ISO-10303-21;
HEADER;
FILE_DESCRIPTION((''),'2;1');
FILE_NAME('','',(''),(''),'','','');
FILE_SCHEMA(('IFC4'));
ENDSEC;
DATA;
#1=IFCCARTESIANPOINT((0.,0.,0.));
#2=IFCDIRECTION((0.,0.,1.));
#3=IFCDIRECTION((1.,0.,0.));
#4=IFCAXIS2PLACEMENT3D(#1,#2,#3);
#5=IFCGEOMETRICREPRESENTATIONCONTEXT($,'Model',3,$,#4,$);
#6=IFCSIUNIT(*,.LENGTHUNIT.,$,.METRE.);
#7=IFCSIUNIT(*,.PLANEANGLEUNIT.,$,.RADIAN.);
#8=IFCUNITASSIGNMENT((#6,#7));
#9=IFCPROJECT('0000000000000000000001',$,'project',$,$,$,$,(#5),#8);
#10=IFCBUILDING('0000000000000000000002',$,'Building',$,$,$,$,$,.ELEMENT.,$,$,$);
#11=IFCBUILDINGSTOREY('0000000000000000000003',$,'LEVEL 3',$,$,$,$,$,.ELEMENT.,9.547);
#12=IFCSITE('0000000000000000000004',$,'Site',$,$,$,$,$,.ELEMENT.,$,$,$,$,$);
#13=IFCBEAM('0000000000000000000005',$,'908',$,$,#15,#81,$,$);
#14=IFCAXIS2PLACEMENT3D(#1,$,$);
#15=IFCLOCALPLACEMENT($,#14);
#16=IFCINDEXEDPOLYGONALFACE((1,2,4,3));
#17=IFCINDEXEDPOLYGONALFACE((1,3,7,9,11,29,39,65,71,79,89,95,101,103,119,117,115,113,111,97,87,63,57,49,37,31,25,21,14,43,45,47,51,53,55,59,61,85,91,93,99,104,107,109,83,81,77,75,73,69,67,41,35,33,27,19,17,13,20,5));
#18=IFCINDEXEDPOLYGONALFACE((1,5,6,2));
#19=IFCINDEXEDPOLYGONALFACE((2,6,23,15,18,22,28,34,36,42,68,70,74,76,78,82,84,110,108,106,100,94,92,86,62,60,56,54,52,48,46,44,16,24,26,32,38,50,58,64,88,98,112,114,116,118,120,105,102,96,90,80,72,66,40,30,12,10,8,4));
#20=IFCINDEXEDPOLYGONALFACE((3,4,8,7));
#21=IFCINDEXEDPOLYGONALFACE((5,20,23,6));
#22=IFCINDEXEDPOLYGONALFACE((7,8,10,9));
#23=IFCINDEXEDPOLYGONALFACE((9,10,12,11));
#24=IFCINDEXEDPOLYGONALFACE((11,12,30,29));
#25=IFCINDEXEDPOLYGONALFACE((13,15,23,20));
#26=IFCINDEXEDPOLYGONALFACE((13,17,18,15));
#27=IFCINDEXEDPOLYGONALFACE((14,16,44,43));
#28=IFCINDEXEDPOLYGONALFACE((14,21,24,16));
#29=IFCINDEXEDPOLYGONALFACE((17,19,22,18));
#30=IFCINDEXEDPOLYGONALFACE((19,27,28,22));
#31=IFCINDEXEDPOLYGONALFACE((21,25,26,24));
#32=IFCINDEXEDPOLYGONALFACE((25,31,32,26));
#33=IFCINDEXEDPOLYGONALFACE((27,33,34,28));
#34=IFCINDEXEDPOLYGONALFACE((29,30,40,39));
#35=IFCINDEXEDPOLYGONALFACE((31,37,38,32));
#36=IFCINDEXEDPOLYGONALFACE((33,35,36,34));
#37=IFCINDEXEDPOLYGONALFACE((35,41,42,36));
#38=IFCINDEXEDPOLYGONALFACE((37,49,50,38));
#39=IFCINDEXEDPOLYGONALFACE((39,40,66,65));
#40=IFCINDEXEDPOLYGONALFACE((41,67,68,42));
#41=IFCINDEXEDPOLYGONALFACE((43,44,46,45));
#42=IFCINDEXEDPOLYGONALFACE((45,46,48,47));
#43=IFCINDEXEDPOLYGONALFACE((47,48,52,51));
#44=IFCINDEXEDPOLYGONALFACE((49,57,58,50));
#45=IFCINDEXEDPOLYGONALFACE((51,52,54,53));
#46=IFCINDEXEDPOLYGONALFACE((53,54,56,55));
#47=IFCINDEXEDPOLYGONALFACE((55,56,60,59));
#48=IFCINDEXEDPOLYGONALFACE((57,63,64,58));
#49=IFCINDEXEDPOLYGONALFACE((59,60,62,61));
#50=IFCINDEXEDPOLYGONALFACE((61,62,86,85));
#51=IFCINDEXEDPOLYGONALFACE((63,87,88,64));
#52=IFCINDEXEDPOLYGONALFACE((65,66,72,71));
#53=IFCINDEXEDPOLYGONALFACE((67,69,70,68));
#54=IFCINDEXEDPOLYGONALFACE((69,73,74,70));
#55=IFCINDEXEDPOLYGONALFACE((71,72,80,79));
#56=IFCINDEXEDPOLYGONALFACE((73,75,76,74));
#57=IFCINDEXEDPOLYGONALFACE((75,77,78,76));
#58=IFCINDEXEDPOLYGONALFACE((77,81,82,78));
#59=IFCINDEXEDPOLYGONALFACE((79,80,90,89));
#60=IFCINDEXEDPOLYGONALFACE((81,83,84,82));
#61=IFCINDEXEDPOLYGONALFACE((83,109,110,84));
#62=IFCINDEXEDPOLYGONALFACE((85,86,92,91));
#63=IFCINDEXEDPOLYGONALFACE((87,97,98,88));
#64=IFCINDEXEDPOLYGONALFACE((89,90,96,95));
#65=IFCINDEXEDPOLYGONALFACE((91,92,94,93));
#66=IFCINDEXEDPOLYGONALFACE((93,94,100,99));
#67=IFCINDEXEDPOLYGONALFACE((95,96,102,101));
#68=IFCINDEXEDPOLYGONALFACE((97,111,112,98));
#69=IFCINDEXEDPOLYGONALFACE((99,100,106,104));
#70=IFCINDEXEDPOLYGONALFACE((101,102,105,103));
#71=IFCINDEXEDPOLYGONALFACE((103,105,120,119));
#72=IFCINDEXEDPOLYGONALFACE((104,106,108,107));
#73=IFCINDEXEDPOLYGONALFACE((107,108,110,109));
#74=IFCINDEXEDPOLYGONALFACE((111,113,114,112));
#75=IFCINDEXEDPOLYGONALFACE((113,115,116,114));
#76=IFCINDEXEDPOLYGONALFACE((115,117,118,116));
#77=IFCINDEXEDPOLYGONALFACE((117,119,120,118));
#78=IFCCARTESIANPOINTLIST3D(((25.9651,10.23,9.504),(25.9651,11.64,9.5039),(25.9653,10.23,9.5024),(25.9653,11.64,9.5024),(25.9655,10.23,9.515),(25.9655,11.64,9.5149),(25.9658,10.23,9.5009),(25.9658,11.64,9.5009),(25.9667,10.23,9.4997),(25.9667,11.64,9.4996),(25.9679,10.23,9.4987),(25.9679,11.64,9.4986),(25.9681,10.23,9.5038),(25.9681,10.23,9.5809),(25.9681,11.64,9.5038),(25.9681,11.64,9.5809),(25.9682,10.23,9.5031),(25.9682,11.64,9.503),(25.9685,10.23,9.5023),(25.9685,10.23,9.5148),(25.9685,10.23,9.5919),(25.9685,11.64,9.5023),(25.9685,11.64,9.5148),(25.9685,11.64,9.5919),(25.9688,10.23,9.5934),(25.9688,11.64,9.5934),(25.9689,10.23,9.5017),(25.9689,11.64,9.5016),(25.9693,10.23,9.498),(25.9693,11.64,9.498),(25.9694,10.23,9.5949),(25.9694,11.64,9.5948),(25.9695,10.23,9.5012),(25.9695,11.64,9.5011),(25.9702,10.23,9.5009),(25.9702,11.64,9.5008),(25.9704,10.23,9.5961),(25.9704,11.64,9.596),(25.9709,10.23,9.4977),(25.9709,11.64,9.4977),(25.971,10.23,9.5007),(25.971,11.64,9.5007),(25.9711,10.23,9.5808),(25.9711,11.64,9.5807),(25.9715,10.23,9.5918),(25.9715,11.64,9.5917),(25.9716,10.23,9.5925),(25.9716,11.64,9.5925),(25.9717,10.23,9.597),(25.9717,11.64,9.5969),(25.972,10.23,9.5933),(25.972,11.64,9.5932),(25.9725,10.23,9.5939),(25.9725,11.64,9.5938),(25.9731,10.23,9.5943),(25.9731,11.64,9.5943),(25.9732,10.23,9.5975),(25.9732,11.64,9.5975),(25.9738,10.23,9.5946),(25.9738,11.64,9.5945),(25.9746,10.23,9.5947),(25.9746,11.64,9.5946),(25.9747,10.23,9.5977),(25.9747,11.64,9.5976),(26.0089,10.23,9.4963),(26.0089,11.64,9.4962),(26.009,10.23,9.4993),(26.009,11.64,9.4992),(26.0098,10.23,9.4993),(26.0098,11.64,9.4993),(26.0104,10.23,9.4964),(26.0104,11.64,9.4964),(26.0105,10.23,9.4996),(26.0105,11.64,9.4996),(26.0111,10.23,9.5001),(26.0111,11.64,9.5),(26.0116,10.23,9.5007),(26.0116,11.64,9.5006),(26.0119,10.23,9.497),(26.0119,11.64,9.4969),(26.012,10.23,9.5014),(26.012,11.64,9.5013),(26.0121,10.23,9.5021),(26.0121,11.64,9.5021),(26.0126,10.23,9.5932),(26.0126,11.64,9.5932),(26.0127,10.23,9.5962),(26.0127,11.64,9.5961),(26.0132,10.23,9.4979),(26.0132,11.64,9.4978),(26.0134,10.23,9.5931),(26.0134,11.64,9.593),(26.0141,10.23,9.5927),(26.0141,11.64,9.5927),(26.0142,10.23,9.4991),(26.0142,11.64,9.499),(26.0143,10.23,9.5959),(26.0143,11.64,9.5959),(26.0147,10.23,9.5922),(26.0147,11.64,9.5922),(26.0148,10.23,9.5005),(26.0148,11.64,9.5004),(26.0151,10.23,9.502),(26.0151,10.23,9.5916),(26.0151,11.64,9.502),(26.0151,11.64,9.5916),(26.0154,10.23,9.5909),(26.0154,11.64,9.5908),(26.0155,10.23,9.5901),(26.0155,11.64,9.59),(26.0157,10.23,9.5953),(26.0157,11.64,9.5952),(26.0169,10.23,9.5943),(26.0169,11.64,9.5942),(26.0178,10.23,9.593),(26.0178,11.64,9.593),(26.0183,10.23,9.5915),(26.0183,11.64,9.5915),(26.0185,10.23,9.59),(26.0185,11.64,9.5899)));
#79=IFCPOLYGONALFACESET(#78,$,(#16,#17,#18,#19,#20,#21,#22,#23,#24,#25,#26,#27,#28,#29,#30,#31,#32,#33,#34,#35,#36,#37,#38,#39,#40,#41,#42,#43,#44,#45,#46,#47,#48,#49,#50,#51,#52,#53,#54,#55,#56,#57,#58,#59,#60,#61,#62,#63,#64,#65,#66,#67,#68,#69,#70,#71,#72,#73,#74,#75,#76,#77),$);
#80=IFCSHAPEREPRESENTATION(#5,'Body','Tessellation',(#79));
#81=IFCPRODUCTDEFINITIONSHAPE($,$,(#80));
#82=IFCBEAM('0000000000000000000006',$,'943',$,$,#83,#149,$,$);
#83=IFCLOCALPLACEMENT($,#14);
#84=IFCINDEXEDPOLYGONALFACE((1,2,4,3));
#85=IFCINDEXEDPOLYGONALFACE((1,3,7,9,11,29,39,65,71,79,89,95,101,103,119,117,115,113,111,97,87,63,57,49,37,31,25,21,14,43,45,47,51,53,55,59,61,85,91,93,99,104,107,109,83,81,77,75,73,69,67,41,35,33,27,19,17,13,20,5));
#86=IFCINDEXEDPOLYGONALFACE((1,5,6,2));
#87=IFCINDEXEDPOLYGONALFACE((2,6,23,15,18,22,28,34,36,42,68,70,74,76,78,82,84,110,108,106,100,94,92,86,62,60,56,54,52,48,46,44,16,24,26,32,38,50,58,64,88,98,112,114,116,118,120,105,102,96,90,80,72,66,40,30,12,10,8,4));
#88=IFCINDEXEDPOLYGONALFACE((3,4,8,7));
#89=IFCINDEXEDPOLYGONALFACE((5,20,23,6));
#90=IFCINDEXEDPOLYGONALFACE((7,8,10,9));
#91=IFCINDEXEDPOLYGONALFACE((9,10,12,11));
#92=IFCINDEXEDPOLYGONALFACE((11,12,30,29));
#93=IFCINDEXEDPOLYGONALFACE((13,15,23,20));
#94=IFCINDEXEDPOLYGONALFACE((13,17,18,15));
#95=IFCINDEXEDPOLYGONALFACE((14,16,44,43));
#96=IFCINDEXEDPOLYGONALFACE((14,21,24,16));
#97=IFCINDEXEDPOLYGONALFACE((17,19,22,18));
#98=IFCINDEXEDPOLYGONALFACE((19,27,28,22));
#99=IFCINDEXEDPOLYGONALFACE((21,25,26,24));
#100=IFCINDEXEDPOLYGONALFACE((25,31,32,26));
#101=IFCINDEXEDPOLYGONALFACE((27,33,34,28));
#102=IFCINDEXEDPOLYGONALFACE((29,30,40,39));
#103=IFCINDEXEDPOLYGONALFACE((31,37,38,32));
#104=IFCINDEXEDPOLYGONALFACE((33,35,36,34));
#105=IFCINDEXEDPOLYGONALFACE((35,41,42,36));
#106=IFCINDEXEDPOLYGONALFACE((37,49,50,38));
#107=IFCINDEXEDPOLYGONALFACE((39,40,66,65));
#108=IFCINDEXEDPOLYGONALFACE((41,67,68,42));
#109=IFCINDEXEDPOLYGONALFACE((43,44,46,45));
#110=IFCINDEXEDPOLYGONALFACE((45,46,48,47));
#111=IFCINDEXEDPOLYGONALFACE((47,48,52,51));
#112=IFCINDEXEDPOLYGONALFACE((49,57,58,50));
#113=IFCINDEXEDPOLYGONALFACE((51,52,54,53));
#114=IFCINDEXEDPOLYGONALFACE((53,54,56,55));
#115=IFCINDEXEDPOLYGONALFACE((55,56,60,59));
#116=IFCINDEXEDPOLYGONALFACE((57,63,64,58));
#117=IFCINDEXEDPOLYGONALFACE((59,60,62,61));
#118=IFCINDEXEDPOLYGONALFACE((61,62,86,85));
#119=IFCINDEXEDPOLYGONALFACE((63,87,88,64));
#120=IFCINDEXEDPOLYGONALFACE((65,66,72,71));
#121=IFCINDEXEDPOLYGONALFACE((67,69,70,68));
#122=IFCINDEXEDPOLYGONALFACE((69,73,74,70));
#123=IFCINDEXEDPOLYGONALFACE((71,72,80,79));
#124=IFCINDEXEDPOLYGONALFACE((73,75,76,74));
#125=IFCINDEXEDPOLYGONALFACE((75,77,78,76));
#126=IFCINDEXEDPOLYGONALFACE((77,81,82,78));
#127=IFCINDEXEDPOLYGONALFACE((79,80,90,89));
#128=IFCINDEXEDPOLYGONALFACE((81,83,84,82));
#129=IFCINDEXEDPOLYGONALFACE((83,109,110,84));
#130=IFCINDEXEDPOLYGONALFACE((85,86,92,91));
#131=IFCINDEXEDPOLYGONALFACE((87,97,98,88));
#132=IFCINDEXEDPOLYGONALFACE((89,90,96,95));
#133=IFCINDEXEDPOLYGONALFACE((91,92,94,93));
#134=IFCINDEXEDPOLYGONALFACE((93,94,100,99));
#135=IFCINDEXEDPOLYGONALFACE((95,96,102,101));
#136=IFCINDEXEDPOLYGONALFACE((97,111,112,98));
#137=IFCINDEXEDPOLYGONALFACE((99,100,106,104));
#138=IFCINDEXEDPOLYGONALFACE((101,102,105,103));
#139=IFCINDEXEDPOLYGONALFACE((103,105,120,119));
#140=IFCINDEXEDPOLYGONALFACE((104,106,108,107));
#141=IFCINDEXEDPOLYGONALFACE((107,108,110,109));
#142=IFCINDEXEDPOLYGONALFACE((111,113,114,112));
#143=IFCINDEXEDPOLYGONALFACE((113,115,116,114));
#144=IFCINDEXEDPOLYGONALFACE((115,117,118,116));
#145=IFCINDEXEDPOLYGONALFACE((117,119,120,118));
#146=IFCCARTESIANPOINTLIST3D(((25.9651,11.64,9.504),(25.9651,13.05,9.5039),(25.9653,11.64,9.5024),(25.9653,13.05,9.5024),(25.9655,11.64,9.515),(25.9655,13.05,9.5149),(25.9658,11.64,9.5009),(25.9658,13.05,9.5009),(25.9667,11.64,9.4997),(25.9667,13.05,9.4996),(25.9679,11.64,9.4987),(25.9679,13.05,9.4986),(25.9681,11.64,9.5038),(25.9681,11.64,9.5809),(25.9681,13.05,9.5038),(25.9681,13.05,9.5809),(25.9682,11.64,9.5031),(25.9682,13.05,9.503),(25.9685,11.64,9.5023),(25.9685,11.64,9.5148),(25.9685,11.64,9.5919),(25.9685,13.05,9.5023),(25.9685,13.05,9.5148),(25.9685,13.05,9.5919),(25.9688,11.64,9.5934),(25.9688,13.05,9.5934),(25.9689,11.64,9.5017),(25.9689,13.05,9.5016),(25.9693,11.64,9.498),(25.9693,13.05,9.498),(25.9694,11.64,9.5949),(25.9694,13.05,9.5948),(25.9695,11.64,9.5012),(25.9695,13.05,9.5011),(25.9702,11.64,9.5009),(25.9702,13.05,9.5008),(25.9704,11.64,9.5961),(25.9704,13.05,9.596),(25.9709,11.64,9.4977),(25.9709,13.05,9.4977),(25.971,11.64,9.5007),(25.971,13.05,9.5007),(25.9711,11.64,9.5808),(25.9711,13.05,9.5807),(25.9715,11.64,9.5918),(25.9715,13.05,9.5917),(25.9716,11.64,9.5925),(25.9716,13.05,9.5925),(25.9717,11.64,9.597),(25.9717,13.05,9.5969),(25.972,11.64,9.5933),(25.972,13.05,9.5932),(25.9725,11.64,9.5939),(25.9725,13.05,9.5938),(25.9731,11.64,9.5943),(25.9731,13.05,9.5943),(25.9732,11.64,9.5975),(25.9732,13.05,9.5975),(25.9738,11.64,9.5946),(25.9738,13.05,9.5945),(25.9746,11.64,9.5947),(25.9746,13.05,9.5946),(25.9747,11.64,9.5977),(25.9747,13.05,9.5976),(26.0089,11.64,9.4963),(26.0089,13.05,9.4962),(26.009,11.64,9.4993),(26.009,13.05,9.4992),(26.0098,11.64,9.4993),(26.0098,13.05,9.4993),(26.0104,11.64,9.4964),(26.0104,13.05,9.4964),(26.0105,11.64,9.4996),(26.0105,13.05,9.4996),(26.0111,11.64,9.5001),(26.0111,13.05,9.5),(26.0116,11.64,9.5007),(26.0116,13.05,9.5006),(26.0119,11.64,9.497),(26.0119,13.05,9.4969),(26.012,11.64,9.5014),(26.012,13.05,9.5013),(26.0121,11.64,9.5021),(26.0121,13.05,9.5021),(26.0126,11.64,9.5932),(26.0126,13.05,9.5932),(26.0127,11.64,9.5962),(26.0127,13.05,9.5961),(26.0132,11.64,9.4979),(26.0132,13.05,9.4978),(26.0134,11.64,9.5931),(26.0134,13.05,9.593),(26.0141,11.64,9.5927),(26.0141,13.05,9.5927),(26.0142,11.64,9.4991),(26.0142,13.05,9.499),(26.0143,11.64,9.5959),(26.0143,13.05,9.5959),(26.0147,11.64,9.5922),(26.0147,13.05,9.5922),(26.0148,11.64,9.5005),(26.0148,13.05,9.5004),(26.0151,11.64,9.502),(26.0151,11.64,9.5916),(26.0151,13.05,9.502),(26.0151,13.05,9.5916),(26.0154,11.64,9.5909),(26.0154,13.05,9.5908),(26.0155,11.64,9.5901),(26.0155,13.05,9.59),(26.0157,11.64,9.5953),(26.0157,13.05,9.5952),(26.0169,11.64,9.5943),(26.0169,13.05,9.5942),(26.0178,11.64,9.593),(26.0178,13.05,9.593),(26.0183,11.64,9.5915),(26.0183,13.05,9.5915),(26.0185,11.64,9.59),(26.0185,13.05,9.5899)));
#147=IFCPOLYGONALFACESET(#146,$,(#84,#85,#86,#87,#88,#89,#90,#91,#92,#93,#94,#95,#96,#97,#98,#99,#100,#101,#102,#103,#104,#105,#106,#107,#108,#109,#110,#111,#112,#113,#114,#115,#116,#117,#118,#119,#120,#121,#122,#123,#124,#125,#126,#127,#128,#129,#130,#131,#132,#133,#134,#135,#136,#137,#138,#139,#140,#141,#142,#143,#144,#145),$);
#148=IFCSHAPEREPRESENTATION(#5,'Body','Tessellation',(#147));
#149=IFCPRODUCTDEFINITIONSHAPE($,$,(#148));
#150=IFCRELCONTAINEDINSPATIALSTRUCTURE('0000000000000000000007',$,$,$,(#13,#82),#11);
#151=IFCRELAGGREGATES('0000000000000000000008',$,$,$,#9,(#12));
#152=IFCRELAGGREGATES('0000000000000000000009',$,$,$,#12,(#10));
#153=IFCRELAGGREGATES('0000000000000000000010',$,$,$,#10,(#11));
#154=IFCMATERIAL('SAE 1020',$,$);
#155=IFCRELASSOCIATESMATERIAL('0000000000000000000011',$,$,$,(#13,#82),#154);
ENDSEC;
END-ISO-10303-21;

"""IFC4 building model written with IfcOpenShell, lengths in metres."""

from ifc_helpers import new_model, si_unit, frame, origin_with_axes, origin_2d_with_axis, place, context, project, spatial, c_section, extrude, material, material_profile, profile_set, profile_usage, element, save


model = new_model("IFC4")

# Units and contexts
model_context = context("Model", 3, world=origin_with_axes())
ifc_project = project(units=[si_unit("LENGTHUNIT", "METRE"), si_unit("PLANEANGLEUNIT", "RADIAN")], contexts=[model_context])

# Site, building, storey
site = spatial("IfcSite", under=ifc_project, Name="Site", CompositionType="ELEMENT")
building = spatial("IfcBuilding", under=site, Name="Building", CompositionType="ELEMENT")
storey = spatial("IfcBuildingStorey", under=building, Name="LEVEL 3", CompositionType="ELEMENT", Elevation=9.547)

# Beams
ifc_material = material(Name="SAE 1020")
ifc_material_profile_1 = material_profile(ifc_material, c_section(Depth=0.1, Width=0.05, WallThickness=0.003, Girth=0.017, InternalFilletRadius=0.003, at=origin_2d_with_axis()))
ifc_profile_set_1 = profile_set([ifc_material_profile_1])
ifc_profile_usage_1 = profile_usage(ifc_profile_set_1, cardinal=10)
beam_1_placement = place(None, frame((25.9918, 10.23, 9.547), z_axis=(0.0, 1.0, -0.00003), x_axis=(-0.999256, 0.000001, 0.038562)))
element("IfcBeam", 1, at=beam_1_placement, inside=storey, material=ifc_profile_usage_1, Name="908", context=model_context, shape_type="SweptSolid", body=[
    extrude(c_section(Depth=0.1, Width=0.05, WallThickness=0.003, Girth=0.017, InternalFilletRadius=0.003, at=origin_2d_with_axis()), origin_with_axes(), (0.0, 0.0, 1.0), 1.41),
])
ifc_material_profile_2 = material_profile(ifc_material, c_section(Depth=0.1, Width=0.05, WallThickness=0.003, Girth=0.017, InternalFilletRadius=0.003, at=origin_2d_with_axis()))
ifc_profile_set_2 = profile_set([ifc_material_profile_2])
ifc_profile_usage_2 = profile_usage(ifc_profile_set_2, cardinal=10)
beam_2_placement = place(None, frame((25.9918, 11.64, 9.547), z_axis=(0.0, 1.0, -0.00003), x_axis=(-0.999256, 0.000001, 0.038562)))
element("IfcBeam", 2, at=beam_2_placement, inside=storey, material=ifc_profile_usage_2, Name="943", context=model_context, shape_type="SweptSolid", body=[
    extrude(c_section(Depth=0.1, Width=0.05, WallThickness=0.003, Girth=0.017, InternalFilletRadius=0.003, at=origin_2d_with_axis()), origin_with_axes(), (0.0, 0.0, 1.0), 1.41),
])

save(model, "model.ifc")
